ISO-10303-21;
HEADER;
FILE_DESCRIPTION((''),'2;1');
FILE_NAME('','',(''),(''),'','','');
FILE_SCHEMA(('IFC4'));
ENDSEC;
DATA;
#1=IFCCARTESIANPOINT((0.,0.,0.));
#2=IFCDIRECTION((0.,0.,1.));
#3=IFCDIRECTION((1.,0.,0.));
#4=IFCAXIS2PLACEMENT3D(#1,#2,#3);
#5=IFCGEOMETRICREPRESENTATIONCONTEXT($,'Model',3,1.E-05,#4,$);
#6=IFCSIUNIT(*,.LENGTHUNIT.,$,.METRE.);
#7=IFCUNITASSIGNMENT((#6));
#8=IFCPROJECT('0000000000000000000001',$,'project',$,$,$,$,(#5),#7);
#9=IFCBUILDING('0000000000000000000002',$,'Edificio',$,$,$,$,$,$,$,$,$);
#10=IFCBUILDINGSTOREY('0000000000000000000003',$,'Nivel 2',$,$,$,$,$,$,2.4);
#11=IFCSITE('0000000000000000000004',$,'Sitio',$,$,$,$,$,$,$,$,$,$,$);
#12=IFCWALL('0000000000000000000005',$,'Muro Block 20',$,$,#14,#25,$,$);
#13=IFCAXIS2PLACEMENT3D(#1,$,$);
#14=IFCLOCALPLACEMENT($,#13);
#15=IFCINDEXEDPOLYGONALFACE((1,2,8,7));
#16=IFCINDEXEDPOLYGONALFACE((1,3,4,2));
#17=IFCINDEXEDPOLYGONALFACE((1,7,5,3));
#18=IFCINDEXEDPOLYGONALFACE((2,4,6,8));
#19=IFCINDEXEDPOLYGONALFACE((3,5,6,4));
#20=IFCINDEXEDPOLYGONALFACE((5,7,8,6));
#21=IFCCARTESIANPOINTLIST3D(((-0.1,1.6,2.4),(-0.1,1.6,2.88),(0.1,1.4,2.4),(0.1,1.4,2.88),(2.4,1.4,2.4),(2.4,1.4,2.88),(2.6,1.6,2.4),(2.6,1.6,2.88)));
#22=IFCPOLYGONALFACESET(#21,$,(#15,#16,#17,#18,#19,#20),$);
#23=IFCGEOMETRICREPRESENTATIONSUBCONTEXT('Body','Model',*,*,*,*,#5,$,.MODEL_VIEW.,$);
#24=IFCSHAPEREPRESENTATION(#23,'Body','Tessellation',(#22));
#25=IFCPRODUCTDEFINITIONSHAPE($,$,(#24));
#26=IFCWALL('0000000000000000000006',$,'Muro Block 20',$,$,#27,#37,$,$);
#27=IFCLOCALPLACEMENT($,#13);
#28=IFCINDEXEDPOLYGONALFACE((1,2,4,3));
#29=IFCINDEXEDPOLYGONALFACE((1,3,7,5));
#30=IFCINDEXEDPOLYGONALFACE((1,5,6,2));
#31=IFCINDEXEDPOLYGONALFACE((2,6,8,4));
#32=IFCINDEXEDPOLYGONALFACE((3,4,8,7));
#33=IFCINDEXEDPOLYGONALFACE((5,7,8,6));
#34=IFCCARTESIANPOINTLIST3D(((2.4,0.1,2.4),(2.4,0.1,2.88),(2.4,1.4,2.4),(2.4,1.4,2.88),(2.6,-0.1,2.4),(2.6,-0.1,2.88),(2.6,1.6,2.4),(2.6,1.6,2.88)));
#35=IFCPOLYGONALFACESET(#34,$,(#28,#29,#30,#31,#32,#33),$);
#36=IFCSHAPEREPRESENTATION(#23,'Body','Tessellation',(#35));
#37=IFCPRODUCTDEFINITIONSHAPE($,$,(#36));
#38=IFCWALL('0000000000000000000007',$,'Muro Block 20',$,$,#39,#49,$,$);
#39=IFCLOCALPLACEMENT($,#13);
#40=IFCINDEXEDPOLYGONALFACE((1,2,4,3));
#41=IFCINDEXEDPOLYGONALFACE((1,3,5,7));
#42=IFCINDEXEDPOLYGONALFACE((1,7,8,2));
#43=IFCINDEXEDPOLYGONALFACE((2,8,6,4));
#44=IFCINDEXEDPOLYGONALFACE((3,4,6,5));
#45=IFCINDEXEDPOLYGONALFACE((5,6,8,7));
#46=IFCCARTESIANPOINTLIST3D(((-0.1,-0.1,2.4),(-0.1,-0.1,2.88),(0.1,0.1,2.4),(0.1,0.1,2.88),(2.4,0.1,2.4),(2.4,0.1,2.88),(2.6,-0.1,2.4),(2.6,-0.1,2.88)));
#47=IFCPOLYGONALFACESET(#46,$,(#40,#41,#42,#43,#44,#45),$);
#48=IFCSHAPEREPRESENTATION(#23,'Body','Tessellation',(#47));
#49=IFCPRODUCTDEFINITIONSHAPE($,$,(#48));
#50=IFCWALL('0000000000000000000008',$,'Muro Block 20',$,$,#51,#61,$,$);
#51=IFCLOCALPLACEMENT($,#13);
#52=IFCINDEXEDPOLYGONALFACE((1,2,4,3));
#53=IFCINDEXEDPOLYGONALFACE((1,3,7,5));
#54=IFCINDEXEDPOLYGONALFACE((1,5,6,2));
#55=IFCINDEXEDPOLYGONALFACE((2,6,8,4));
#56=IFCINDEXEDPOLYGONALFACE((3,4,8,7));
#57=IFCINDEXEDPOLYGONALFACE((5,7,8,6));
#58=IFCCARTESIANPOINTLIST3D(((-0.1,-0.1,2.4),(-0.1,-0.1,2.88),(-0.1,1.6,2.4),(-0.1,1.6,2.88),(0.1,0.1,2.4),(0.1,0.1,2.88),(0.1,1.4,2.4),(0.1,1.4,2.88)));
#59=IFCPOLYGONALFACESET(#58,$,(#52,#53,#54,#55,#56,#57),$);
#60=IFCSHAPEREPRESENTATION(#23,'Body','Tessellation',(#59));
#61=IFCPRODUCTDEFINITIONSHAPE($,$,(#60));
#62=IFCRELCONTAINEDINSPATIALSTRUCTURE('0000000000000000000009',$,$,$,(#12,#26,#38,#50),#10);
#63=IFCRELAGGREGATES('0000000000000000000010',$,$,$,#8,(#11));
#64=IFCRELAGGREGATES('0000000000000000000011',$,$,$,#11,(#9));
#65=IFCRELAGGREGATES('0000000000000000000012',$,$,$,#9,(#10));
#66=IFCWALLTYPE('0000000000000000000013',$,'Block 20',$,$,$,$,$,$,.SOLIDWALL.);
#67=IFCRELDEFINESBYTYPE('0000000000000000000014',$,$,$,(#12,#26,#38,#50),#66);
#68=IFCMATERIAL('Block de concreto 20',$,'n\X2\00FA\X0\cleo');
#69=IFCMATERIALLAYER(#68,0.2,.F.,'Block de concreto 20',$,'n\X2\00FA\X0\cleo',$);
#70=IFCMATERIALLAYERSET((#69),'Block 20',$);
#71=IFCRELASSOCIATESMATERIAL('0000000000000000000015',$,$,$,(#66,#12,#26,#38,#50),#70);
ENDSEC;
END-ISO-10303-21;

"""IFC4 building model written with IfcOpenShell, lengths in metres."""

from ifc_helpers import new_model, si_unit, frame, origin_with_axes, place, context, subcontext, project, spatial, indexed_curve, outline, extrude, material, layer, layer_set, layer_usage, type_object, element, save


model = new_model("IFC4")

# Units and contexts
model_context = context("Model", 3, precision=1e-05, world=origin_with_axes())
body_context = subcontext(model_context, "Body", "Model", "MODEL_VIEW")
ifc_project = project(units=[si_unit("LENGTHUNIT", "METRE")], contexts=[model_context])

# Site, building, storey
site = spatial("IfcSite", under=ifc_project, Name="Sitio")
building = spatial("IfcBuilding", under=site, Name="Edificio")
storey = spatial("IfcBuildingStorey", under=building, Name="Nivel 2", Elevation=2.4)

# Walls
ifc_material = material(Name="Block de concreto 20", Category="núcleo")
ifc_layer = layer(ifc_material, 0.2, ventilated=False, Name="Block de concreto 20", Category="núcleo")
ifc_layer_set = layer_set([ifc_layer], Name="Block 20")
ifc_layer_usage_1 = layer_usage(ifc_layer_set, "AXIS2", "POSITIVE", 0.0)
wall_type = type_object("IfcWallType", Name="Block 20", PredefinedType="SOLIDWALL", material=ifc_layer_set)
wall_1_placement = place(None, frame((0.0, 1.5, 2.4), z_axis=(0.0, 0.0, 1.0), x_axis=(1.0, 0.0, 0.0)))
element("IfcWall", 1, at=wall_1_placement, inside=storey, type_object=wall_type, material=ifc_layer_usage_1, Name="Muro Block 20", context=body_context, shape_type="SweptSolid", body=[
    extrude(outline(indexed_curve([(0.1, -0.1), (2.4, -0.1), (2.6, 0.1), (-0.1, 0.1)])), None, (0.0, 0.0, 1.0), 0.48),
])
ifc_layer_usage_2 = layer_usage(ifc_layer_set, "AXIS2", "POSITIVE", 0.0)
wall_2_placement = place(None, frame((2.5, 1.5, 2.4), z_axis=(0.0, 0.0, 1.0), x_axis=(0.0, -1.0, 0.0)))
element("IfcWall", 2, at=wall_2_placement, inside=storey, type_object=wall_type, material=ifc_layer_usage_2, Name="Muro Block 20", context=body_context, shape_type="SweptSolid", body=[
    extrude(outline(indexed_curve([(0.1, -0.1), (1.4, -0.1), (1.6, 0.1), (-0.1, 0.1)])), None, (0.0, 0.0, 1.0), 0.48),
])
ifc_layer_usage_3 = layer_usage(ifc_layer_set, "AXIS2", "POSITIVE", 0.0)
wall_3_placement = place(None, frame((2.5, 0.0, 2.4), z_axis=(0.0, 0.0, 1.0), x_axis=(-1.0, 0.0, 0.0)))
element("IfcWall", 3, at=wall_3_placement, inside=storey, type_object=wall_type, material=ifc_layer_usage_3, Name="Muro Block 20", context=body_context, shape_type="SweptSolid", body=[
    extrude(outline(indexed_curve([(0.1, -0.1), (2.4, -0.1), (2.6, 0.1), (-0.1, 0.1)])), None, (0.0, 0.0, 1.0), 0.48),
])
ifc_layer_usage_4 = layer_usage(ifc_layer_set, "AXIS2", "POSITIVE", 0.0)
wall_4_placement = place(None, frame((0.0, 0.0, 2.4), z_axis=(0.0, 0.0, 1.0), x_axis=(0.0, 1.0, 0.0)))
element("IfcWall", 4, at=wall_4_placement, inside=storey, type_object=wall_type, material=ifc_layer_usage_4, Name="Muro Block 20", context=body_context, shape_type="SweptSolid", body=[
    extrude(outline(indexed_curve([(0.1, -0.1), (1.4, -0.1), (1.6, 0.1), (-0.1, 0.1)])), None, (0.0, 0.0, 1.0), 0.48),
])

save(model, "model.ifc")
